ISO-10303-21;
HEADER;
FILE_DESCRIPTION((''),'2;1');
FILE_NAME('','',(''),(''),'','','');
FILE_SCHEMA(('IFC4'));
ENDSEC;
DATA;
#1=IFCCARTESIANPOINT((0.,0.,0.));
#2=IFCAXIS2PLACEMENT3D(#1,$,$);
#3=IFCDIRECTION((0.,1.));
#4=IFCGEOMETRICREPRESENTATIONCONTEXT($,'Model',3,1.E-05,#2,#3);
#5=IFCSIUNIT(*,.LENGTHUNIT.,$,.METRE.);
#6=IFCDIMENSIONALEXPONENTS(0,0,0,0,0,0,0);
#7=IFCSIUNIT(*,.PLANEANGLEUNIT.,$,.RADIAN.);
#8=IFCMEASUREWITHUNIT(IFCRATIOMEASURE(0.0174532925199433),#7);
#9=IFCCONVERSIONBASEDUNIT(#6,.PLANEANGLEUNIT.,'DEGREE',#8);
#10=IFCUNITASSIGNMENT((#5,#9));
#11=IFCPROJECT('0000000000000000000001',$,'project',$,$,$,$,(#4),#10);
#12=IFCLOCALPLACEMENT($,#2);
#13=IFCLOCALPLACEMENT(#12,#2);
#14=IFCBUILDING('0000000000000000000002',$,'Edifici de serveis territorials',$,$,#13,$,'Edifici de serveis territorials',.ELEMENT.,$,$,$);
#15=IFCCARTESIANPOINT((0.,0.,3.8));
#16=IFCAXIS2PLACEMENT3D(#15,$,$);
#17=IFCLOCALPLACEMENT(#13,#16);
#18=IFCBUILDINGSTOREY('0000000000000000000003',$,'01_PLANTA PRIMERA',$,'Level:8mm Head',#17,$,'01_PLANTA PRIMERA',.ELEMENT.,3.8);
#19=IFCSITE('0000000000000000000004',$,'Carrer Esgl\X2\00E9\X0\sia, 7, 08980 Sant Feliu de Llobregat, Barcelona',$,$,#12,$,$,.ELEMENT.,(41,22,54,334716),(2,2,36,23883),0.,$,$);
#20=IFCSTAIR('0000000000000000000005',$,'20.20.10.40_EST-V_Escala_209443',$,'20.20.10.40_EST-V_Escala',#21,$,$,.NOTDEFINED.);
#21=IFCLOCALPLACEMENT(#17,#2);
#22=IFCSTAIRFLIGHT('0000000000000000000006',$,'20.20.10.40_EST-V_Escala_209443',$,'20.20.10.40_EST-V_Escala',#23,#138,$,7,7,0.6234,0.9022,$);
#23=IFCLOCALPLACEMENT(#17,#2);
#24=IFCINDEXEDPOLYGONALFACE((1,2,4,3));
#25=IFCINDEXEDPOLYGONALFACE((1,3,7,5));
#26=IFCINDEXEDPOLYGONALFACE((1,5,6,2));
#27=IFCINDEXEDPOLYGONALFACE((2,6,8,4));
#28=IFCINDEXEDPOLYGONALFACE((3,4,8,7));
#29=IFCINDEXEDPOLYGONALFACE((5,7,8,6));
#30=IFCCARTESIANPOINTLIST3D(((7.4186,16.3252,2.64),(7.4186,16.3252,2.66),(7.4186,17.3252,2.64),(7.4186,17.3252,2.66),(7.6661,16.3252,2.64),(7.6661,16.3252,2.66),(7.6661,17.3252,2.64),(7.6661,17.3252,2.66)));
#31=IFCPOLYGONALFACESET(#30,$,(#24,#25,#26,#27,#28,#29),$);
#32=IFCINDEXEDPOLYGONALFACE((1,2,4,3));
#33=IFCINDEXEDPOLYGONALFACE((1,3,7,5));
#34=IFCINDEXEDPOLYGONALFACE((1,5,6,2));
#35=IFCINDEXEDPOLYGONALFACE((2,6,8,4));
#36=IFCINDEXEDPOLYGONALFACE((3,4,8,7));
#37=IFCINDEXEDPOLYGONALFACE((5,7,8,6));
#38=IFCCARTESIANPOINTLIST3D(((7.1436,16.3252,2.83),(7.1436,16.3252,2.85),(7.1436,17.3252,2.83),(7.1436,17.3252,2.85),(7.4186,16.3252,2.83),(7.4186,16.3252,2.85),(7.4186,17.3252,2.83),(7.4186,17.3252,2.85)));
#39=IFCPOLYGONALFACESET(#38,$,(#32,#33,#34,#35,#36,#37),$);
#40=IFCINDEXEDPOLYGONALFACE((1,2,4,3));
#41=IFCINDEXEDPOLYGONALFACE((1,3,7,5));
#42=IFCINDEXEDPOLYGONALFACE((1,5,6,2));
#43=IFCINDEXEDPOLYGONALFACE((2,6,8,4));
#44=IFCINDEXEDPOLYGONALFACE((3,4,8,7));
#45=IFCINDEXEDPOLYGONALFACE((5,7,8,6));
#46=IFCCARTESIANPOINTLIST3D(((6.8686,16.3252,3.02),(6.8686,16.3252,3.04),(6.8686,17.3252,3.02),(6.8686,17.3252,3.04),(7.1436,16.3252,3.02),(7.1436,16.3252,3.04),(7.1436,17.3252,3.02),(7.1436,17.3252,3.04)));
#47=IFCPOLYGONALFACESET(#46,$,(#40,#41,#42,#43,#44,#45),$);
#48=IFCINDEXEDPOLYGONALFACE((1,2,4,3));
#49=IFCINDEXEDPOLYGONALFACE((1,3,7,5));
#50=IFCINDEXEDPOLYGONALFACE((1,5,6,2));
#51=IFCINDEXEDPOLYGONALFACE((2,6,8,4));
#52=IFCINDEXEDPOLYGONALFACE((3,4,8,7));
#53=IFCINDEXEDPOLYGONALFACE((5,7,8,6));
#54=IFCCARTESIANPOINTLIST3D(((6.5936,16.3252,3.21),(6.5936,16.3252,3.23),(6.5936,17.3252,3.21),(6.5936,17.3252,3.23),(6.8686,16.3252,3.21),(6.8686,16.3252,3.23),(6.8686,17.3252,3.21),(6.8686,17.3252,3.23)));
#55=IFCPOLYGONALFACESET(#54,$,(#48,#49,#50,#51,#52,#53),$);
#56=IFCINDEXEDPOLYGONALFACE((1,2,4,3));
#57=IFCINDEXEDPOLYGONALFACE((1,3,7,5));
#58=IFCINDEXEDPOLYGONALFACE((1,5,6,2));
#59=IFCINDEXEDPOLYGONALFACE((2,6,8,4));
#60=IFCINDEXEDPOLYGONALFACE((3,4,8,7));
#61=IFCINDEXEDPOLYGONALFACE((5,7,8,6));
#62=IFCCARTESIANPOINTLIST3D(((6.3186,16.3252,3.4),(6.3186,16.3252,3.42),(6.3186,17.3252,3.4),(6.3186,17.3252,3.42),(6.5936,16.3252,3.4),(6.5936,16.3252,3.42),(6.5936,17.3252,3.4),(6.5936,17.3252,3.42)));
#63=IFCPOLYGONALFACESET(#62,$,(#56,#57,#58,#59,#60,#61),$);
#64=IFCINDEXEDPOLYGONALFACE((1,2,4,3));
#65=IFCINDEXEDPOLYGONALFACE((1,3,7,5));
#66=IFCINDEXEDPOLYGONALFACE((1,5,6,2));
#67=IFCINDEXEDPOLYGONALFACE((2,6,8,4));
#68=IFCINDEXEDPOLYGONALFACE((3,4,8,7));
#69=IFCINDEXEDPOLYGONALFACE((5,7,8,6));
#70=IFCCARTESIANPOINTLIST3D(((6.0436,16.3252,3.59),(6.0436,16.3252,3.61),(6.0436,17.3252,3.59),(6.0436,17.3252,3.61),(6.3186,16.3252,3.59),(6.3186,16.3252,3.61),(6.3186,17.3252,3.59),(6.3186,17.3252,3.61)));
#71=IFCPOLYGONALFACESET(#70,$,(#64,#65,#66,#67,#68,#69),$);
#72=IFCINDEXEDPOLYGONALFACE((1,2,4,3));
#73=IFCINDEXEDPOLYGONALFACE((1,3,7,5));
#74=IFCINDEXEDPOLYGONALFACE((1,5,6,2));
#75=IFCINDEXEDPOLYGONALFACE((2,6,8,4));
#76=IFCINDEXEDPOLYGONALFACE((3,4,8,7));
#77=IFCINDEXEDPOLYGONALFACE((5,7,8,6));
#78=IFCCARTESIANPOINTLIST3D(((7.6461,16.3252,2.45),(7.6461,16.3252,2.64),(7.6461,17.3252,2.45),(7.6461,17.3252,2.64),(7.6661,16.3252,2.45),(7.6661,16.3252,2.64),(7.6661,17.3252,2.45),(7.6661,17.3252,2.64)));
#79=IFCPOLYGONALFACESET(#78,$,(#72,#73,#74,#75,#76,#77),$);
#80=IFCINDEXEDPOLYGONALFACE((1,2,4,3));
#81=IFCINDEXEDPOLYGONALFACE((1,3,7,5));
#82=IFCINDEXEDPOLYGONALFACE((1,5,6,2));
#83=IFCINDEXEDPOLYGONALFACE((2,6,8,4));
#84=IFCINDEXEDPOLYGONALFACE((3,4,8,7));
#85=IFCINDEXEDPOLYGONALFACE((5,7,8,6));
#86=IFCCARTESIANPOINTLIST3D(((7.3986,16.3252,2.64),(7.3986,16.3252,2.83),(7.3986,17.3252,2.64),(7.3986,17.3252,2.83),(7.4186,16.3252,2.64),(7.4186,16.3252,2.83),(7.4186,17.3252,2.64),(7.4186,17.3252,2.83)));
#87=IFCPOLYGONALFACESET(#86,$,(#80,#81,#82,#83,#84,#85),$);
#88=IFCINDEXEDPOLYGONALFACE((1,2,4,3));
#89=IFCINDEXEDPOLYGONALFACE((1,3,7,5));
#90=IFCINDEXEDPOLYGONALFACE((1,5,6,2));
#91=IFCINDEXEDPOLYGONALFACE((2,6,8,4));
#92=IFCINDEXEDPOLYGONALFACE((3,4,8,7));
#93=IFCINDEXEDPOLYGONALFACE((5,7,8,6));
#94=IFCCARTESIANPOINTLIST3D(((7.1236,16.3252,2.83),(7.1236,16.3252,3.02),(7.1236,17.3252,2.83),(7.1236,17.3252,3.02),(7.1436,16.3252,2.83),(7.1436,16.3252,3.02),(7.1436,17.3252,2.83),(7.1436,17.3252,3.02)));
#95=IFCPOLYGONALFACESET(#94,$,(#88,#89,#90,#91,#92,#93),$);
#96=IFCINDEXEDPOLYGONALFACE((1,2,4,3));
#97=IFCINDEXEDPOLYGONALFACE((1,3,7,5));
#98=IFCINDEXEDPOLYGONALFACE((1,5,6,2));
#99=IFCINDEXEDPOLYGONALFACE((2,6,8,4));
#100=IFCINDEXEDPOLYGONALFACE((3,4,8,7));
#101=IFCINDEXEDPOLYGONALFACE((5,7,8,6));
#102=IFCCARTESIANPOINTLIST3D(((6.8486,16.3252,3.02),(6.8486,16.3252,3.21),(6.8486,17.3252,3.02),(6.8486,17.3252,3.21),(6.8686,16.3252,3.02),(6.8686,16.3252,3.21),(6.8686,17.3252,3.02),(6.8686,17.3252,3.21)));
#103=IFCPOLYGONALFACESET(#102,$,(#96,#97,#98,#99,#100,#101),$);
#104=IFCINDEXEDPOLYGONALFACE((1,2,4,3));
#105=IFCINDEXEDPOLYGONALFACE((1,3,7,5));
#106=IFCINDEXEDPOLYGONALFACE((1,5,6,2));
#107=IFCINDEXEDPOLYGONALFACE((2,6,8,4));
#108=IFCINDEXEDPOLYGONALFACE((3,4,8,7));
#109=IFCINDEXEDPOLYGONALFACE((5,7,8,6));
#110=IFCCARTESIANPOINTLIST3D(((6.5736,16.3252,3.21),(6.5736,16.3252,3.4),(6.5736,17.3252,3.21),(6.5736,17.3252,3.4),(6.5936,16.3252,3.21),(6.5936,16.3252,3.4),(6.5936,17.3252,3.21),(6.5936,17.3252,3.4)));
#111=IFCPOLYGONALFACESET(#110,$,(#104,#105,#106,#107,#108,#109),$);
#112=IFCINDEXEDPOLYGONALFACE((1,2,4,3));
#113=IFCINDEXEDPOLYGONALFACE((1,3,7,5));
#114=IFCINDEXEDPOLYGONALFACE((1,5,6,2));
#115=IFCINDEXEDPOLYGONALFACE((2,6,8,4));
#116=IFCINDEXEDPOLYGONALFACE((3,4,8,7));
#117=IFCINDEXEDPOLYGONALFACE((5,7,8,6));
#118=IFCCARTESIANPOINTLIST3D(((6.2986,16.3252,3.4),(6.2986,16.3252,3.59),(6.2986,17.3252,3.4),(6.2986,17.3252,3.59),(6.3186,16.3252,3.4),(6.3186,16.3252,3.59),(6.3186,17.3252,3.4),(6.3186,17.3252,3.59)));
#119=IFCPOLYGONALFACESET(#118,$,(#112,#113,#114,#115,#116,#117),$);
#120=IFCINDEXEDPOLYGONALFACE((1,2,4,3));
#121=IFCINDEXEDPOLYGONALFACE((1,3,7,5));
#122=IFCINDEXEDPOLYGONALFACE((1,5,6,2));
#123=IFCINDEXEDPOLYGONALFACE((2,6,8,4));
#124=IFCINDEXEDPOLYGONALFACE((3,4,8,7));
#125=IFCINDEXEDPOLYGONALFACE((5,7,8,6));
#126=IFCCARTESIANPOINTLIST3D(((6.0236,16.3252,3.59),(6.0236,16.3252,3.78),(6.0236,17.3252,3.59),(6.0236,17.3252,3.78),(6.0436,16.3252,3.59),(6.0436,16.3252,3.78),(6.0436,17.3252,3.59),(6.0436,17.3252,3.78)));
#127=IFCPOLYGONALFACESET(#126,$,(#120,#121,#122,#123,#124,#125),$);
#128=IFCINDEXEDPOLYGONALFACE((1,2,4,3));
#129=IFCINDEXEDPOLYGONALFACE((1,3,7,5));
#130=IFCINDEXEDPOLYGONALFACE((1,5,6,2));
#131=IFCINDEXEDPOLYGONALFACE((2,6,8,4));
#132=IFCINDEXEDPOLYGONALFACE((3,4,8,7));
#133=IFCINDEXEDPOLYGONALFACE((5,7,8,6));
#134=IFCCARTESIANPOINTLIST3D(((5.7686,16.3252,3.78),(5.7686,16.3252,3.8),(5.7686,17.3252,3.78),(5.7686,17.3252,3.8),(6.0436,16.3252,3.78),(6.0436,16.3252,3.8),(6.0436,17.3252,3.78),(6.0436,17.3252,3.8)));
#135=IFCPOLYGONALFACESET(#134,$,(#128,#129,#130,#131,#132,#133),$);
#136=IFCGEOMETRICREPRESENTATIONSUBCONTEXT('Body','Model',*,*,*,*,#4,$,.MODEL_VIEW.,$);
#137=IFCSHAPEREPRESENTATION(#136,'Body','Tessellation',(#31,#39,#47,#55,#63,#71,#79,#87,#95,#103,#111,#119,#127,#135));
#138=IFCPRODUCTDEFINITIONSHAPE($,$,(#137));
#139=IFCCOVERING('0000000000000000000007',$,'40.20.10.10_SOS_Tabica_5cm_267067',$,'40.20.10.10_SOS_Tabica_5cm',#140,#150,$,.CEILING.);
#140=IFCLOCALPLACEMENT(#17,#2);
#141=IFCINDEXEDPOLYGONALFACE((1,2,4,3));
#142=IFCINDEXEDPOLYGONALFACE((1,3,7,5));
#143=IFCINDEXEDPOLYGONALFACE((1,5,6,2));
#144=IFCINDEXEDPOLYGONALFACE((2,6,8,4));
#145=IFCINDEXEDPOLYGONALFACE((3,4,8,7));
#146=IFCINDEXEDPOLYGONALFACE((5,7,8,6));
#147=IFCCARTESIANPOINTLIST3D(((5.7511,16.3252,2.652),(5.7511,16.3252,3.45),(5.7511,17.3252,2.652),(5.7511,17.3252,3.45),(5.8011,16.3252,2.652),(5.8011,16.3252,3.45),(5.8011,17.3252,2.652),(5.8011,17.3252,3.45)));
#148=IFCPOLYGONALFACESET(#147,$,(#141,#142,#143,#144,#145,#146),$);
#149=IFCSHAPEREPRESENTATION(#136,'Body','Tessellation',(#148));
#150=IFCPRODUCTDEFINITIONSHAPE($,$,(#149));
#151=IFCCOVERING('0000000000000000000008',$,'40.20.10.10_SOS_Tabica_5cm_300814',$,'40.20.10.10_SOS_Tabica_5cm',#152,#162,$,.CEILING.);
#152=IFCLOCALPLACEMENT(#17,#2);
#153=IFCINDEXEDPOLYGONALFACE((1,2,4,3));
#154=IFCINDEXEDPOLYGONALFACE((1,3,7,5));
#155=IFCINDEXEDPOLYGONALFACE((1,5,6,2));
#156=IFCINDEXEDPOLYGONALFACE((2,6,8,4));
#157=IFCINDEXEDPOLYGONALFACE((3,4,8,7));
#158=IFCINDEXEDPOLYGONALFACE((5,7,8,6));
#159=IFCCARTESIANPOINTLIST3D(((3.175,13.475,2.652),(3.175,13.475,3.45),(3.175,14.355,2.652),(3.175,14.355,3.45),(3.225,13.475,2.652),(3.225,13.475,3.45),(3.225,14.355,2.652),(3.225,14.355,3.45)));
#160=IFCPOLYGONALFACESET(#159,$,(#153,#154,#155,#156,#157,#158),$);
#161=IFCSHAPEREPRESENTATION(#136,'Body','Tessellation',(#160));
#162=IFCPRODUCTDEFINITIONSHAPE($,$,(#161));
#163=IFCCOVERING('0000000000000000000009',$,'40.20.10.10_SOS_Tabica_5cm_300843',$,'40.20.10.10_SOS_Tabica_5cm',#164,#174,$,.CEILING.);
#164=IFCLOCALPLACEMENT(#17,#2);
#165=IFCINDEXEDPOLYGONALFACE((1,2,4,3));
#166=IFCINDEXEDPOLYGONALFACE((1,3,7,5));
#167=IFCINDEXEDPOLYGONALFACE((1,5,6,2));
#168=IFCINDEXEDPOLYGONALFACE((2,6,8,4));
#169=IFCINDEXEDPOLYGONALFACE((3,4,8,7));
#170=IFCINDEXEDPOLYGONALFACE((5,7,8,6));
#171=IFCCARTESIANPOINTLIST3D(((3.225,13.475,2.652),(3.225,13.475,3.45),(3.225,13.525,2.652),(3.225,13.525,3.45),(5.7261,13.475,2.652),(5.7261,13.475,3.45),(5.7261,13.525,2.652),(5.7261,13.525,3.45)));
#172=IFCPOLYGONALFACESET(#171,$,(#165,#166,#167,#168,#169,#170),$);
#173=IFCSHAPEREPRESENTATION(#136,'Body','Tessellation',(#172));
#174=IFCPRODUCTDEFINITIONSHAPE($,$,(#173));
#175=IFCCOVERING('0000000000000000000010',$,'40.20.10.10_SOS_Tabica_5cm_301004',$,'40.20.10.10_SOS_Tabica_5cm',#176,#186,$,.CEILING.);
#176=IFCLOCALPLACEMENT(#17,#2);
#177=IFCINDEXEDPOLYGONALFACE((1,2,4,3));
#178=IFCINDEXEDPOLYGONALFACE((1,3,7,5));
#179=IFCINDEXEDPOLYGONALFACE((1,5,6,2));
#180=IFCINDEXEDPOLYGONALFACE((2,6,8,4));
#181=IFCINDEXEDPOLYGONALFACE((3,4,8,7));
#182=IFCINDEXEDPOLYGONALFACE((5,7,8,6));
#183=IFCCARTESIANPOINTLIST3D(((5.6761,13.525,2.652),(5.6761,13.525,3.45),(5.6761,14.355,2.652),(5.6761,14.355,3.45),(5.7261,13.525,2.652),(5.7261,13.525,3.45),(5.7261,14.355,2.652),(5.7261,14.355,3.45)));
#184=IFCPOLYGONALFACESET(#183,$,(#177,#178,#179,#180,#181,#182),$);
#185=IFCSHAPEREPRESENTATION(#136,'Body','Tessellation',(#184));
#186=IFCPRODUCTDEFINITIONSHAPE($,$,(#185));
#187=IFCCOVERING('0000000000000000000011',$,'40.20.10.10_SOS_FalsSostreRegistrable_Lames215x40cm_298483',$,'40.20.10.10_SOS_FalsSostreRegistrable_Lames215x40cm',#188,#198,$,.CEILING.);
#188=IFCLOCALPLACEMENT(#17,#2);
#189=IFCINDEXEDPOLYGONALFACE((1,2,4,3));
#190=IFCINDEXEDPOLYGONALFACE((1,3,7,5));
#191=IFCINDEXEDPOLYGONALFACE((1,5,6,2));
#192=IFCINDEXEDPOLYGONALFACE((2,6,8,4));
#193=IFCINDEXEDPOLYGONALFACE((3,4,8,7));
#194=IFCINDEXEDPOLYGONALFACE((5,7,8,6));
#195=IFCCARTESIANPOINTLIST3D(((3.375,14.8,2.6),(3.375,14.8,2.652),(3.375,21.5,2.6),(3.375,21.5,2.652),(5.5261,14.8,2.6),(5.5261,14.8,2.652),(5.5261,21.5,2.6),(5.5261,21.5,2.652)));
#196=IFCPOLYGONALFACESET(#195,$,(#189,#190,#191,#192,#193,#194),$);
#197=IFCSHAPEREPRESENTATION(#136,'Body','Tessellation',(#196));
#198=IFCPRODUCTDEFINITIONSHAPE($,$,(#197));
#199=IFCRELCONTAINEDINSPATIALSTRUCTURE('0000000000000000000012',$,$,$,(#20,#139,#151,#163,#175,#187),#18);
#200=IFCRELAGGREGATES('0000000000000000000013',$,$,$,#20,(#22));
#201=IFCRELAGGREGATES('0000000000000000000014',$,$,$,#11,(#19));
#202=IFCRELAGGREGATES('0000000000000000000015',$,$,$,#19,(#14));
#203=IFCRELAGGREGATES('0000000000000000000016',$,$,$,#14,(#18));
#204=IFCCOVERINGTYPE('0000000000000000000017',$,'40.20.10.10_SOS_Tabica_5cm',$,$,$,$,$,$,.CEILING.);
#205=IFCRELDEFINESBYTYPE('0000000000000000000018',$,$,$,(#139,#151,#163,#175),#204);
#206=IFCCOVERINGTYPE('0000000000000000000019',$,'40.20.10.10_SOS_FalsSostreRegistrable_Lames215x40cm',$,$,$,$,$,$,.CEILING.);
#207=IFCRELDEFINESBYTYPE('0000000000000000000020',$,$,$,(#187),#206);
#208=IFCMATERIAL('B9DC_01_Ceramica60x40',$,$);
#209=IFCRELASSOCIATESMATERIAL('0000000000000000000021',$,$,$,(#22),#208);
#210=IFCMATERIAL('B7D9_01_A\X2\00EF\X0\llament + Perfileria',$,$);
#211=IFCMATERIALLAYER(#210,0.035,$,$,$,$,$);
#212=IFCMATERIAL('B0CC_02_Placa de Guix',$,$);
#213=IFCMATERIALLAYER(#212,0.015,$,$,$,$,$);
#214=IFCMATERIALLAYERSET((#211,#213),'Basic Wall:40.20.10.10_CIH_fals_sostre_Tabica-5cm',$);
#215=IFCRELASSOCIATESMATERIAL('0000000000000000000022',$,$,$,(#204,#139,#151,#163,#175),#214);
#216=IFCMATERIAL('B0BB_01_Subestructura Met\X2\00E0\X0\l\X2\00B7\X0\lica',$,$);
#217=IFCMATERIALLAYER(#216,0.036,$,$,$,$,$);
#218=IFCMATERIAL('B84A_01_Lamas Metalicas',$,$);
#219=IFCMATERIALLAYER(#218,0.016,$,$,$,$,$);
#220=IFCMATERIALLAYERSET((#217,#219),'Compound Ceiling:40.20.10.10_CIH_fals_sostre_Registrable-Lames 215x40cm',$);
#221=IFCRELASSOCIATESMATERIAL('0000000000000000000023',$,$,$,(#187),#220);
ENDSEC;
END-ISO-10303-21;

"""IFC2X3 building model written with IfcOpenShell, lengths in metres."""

from ifc_helpers import new_model, entity, si_unit, converted_unit, direction, frame, frame_2d, origin, place, context, subcontext, project, spatial, rectangle, extrude, material, layer, layer_set, layer_usage, type_object, element, aggregate, save


model = new_model("IFC2X3")

# Units and contexts
model_context = context("Model", 3, precision=1e-05, world=origin(), true_north=direction((0.0, 1.0)))
body_context = subcontext(model_context, "Body", "Model", "MODEL_VIEW")
ifc_project = project(units=[si_unit("LENGTHUNIT", "METRE"), converted_unit("PLANEANGLEUNIT", "DEGREE", entity("IfcRatioMeasure", 0.0174532925199433), si_unit("PLANEANGLEUNIT", "RADIAN"), dimensions=[0, 0, 0, 0, 0, 0, 0])], contexts=[model_context])

# Site, building, storey
site_placement = place(None, origin())
site = spatial("IfcSite", under=ifc_project, at=site_placement, Name="Carrer Església, 7, 08980 Sant Feliu de Llobregat, Barcelona", CompositionType="ELEMENT", RefLatitude=(41, 22, 54, 334716), RefLongitude=(2, 2, 36, 23883), RefElevation=0.0)
building_placement = place(site_placement, origin())
building = spatial("IfcBuilding", under=site, at=building_placement, Name="Edifici de serveis territorials", LongName="Edifici de serveis territorials", CompositionType="ELEMENT")
storey_placement = place(building_placement, frame((0.0, 0.0, 3.8)))
storey = spatial("IfcBuildingStorey", under=building, at=storey_placement, Name="01_PLANTA PRIMERA", ObjectType="Level:8mm Head", LongName="01_PLANTA PRIMERA", CompositionType="ELEMENT", Elevation=3.8)

# Shared definitions
ifc_material_1 = material(Name="B9DC_01_Ceramica60x40")

# Stair
stair_placement = place(storey_placement, origin())
stair = element("IfcStair", 1, at=stair_placement, inside=storey, Name="20.20.10.40_EST-V_Escala_209443", ObjectType="20.20.10.40_EST-V_Escala", ShapeType="NOTDEFINED")

# Shared definitions
ifc_material_2 = material(Name="B0CC_02_Placa de Guix")
ifc_material_3 = material(Name="B7D9_01_Aïllament + Perfileria")

# Stair flight
stair_flight_1_placement = place(stair_placement, origin())
stair_flight_1 = element("IfcStairFlight", 2, at=stair_flight_1_placement, material=ifc_material_1, Name="20.20.10.40_EST-V_Escala_209443", ObjectType="20.20.10.40_EST-V_Escala", NumberOfRiser=7, NumberOfTreads=7, RiserHeight=0.6234, TreadLength=0.9022, context=body_context, shape_type="SweptSolid", body=[
    extrude(rectangle(XDim=0.2475, YDim=1.0, at=frame_2d((0.0, 0.0), x_axis=(1.0, 0.0))), frame((7.5424, 16.8252, 2.64)), (0.0, 0.0, 1.0), 0.02),
    extrude(rectangle(XDim=0.275, YDim=1.0, at=frame_2d((0.0, 0.0), x_axis=(1.0, 0.0))), frame((7.2811, 16.8252, 2.83)), (0.0, 0.0, 1.0), 0.02),
    extrude(rectangle(XDim=0.275, YDim=1.0, at=frame_2d((0.0, 0.0), x_axis=(1.0, 0.0))), frame((7.0061, 16.8252, 3.02)), (0.0, 0.0, 1.0), 0.02),
    extrude(rectangle(XDim=0.275, YDim=1.0, at=frame_2d((0.0, 0.0), x_axis=(1.0, 0.0))), frame((6.7311, 16.8252, 3.21)), (0.0, 0.0, 1.0), 0.02),
    extrude(rectangle(XDim=0.275, YDim=1.0, at=frame_2d((0.0, 0.0), x_axis=(1.0, 0.0))), frame((6.4561, 16.8252, 3.4)), (0.0, 0.0, 1.0), 0.02),
    extrude(rectangle(XDim=0.275, YDim=1.0, at=frame_2d((0.0, 0.0), x_axis=(1.0, 0.0))), frame((6.1811, 16.8252, 3.59)), (0.0, 0.0, 1.0), 0.02),
    extrude(rectangle(XDim=1.0, YDim=0.02, at=frame_2d((0.0, 0.0), x_axis=(1.0, 0.0))), frame((7.6561, 16.8252, 2.45), z_axis=(0.0, 0.0, 1.0), x_axis=(0.0, -1.0, 0.0)), (0.0, 0.0, 1.0), 0.19),
    extrude(rectangle(XDim=1.0, YDim=0.02, at=frame_2d((0.0, 0.0), x_axis=(1.0, 0.0))), frame((7.4086, 16.8252, 2.64), z_axis=(0.0, 0.0, 1.0), x_axis=(0.0, -1.0, 0.0)), (0.0, 0.0, 1.0), 0.19),
    extrude(rectangle(XDim=1.0, YDim=0.02, at=frame_2d((0.0, 0.0), x_axis=(1.0, 0.0))), frame((7.1336, 16.8252, 2.83), z_axis=(0.0, 0.0, 1.0), x_axis=(0.0, -1.0, 0.0)), (0.0, 0.0, 1.0), 0.19),
    extrude(rectangle(XDim=1.0, YDim=0.02, at=frame_2d((0.0, 0.0), x_axis=(1.0, 0.0))), frame((6.8586, 16.8252, 3.02), z_axis=(0.0, 0.0, 1.0), x_axis=(0.0, -1.0, 0.0)), (0.0, 0.0, 1.0), 0.19),
    extrude(rectangle(XDim=1.0, YDim=0.02, at=frame_2d((0.0, 0.0), x_axis=(1.0, 0.0))), frame((6.5836, 16.8252, 3.21), z_axis=(0.0, 0.0, 1.0), x_axis=(0.0, -1.0, 0.0)), (0.0, 0.0, 1.0), 0.19),
    extrude(rectangle(XDim=1.0, YDim=0.02, at=frame_2d((0.0, 0.0), x_axis=(1.0, 0.0))), frame((6.3086, 16.8252, 3.4), z_axis=(0.0, 0.0, 1.0), x_axis=(0.0, -1.0, 0.0)), (0.0, 0.0, 1.0), 0.19),
    extrude(rectangle(XDim=1.0, YDim=0.02, at=frame_2d((0.0, 0.0), x_axis=(1.0, 0.0))), frame((6.0336, 16.8252, 3.59), z_axis=(0.0, 0.0, 1.0), x_axis=(0.0, -1.0, 0.0)), (0.0, 0.0, 1.0), 0.19),
    extrude(rectangle(XDim=0.275, YDim=1.0, at=frame_2d((0.0, 0.0), x_axis=(1.0, 0.0))), frame((5.9061, 16.8252, 3.78)), (0.0, 0.0, 1.0), 0.02),
])
aggregate(stair, [stair_flight_1])

# Coverings
ifc_layer_1 = layer(ifc_material_3, 0.035)
ifc_layer_2 = layer(ifc_material_2, 0.015)
ifc_layer_set_1 = layer_set([ifc_layer_1, ifc_layer_2], Name="Basic Wall:40.20.10.10_CIH_fals_sostre_Tabica-5cm")
ifc_layer_usage_1 = layer_usage(ifc_layer_set_1, "AXIS2", "POSITIVE", -0.025)
covering_type_1 = type_object("IfcCoveringType", Name="40.20.10.10_SOS_Tabica_5cm", PredefinedType="CEILING", material=ifc_layer_set_1)
covering_1_placement = place(storey_placement, frame((5.7761, 17.3252, 2.652), z_axis=(0.0, 0.0, 1.0), x_axis=(0.0, -1.0, 0.0)))
element("IfcCovering", 3, at=covering_1_placement, inside=storey, type_object=covering_type_1, material=ifc_layer_usage_1, Name="40.20.10.10_SOS_Tabica_5cm_267067", ObjectType="40.20.10.10_SOS_Tabica_5cm", PredefinedType="CEILING", context=body_context, shape_type="SweptSolid", body=[
    extrude(rectangle(XDim=1.0, YDim=0.05, at=frame_2d((0.5, 0.0), x_axis=(-1.0, 0.0))), origin(), (0.0, 0.0, 1.0), 0.798),
])
ifc_layer_usage_2 = layer_usage(ifc_layer_set_1, "AXIS2", "NEGATIVE", 0.025)
covering_2_placement = place(storey_placement, frame((3.2, 14.355, 2.652), z_axis=(0.0, 0.0, 1.0), x_axis=(0.0, -1.0, 0.0)))
element("IfcCovering", 4, at=covering_2_placement, inside=storey, type_object=covering_type_1, material=ifc_layer_usage_2, Name="40.20.10.10_SOS_Tabica_5cm_300814", ObjectType="40.20.10.10_SOS_Tabica_5cm", PredefinedType="CEILING", context=body_context, shape_type="SweptSolid", body=[
    extrude(rectangle(XDim=0.88, YDim=0.05, at=frame_2d((0.44, 0.0), x_axis=(-1.0, 0.0))), origin(), (0.0, 0.0, 1.0), 0.798),
])
ifc_layer_usage_3 = layer_usage(ifc_layer_set_1, "AXIS2", "NEGATIVE", 0.025)
covering_3_placement = place(storey_placement, frame((3.225, 13.5, 2.652)))
element("IfcCovering", 5, at=covering_3_placement, inside=storey, type_object=covering_type_1, material=ifc_layer_usage_3, Name="40.20.10.10_SOS_Tabica_5cm_300843", ObjectType="40.20.10.10_SOS_Tabica_5cm", PredefinedType="CEILING", context=body_context, shape_type="SweptSolid", body=[
    extrude(rectangle(XDim=2.5011, YDim=0.05, at=frame_2d((1.2505, 0.0), x_axis=(-1.0, 0.0))), origin(), (0.0, 0.0, 1.0), 0.798),
])
ifc_layer_usage_4 = layer_usage(ifc_layer_set_1, "AXIS2", "NEGATIVE", 0.025)
covering_4_placement = place(storey_placement, frame((5.7011, 13.525, 2.652), z_axis=(0.0, 0.0, 1.0), x_axis=(0.0, 1.0, 0.0)))
element("IfcCovering", 6, at=covering_4_placement, inside=storey, type_object=covering_type_1, material=ifc_layer_usage_4, Name="40.20.10.10_SOS_Tabica_5cm_301004", ObjectType="40.20.10.10_SOS_Tabica_5cm", PredefinedType="CEILING", context=body_context, shape_type="SweptSolid", body=[
    extrude(rectangle(XDim=0.83, YDim=0.05, at=frame_2d((0.415, 0.0), x_axis=(-1.0, 0.0))), origin(), (0.0, 0.0, 1.0), 0.798),
])

# Covering
ifc_material_4 = material(Name="B0BB_01_Subestructura Metàl·lica")
ifc_layer_3 = layer(ifc_material_4, 0.036)
ifc_material_5 = material(Name="B84A_01_Lamas Metalicas")
ifc_layer_4 = layer(ifc_material_5, 0.016)
ifc_layer_set_2 = layer_set([ifc_layer_3, ifc_layer_4], Name="Compound Ceiling:40.20.10.10_CIH_fals_sostre_Registrable-Lames 215x40cm")
ifc_layer_usage_5 = layer_usage(ifc_layer_set_2, "AXIS3", "POSITIVE", 0.0)
covering_type_2 = type_object("IfcCoveringType", Name="40.20.10.10_SOS_FalsSostreRegistrable_Lames215x40cm", PredefinedType="CEILING")
covering_5_placement = place(storey_placement, frame((3.375, 14.8, 2.6)))
element("IfcCovering", 7, at=covering_5_placement, inside=storey, type_object=covering_type_2, material=ifc_layer_usage_5, Name="40.20.10.10_SOS_FalsSostreRegistrable_Lames215x40cm_298483", ObjectType="40.20.10.10_SOS_FalsSostreRegistrable_Lames215x40cm", PredefinedType="CEILING", context=body_context, shape_type="SweptSolid", body=[
    extrude(rectangle(XDim=2.1511, YDim=6.7, at=frame_2d((0.0, 0.0), x_axis=(1.0, 0.0))), frame((1.0755, 3.35, 0.0), z_axis=(0.0, 0.0, 1.0), x_axis=(-1.0, 0.0, 0.0)), (0.0, 0.0, 1.0), 0.052),
])

save(model, "model.ifc")
